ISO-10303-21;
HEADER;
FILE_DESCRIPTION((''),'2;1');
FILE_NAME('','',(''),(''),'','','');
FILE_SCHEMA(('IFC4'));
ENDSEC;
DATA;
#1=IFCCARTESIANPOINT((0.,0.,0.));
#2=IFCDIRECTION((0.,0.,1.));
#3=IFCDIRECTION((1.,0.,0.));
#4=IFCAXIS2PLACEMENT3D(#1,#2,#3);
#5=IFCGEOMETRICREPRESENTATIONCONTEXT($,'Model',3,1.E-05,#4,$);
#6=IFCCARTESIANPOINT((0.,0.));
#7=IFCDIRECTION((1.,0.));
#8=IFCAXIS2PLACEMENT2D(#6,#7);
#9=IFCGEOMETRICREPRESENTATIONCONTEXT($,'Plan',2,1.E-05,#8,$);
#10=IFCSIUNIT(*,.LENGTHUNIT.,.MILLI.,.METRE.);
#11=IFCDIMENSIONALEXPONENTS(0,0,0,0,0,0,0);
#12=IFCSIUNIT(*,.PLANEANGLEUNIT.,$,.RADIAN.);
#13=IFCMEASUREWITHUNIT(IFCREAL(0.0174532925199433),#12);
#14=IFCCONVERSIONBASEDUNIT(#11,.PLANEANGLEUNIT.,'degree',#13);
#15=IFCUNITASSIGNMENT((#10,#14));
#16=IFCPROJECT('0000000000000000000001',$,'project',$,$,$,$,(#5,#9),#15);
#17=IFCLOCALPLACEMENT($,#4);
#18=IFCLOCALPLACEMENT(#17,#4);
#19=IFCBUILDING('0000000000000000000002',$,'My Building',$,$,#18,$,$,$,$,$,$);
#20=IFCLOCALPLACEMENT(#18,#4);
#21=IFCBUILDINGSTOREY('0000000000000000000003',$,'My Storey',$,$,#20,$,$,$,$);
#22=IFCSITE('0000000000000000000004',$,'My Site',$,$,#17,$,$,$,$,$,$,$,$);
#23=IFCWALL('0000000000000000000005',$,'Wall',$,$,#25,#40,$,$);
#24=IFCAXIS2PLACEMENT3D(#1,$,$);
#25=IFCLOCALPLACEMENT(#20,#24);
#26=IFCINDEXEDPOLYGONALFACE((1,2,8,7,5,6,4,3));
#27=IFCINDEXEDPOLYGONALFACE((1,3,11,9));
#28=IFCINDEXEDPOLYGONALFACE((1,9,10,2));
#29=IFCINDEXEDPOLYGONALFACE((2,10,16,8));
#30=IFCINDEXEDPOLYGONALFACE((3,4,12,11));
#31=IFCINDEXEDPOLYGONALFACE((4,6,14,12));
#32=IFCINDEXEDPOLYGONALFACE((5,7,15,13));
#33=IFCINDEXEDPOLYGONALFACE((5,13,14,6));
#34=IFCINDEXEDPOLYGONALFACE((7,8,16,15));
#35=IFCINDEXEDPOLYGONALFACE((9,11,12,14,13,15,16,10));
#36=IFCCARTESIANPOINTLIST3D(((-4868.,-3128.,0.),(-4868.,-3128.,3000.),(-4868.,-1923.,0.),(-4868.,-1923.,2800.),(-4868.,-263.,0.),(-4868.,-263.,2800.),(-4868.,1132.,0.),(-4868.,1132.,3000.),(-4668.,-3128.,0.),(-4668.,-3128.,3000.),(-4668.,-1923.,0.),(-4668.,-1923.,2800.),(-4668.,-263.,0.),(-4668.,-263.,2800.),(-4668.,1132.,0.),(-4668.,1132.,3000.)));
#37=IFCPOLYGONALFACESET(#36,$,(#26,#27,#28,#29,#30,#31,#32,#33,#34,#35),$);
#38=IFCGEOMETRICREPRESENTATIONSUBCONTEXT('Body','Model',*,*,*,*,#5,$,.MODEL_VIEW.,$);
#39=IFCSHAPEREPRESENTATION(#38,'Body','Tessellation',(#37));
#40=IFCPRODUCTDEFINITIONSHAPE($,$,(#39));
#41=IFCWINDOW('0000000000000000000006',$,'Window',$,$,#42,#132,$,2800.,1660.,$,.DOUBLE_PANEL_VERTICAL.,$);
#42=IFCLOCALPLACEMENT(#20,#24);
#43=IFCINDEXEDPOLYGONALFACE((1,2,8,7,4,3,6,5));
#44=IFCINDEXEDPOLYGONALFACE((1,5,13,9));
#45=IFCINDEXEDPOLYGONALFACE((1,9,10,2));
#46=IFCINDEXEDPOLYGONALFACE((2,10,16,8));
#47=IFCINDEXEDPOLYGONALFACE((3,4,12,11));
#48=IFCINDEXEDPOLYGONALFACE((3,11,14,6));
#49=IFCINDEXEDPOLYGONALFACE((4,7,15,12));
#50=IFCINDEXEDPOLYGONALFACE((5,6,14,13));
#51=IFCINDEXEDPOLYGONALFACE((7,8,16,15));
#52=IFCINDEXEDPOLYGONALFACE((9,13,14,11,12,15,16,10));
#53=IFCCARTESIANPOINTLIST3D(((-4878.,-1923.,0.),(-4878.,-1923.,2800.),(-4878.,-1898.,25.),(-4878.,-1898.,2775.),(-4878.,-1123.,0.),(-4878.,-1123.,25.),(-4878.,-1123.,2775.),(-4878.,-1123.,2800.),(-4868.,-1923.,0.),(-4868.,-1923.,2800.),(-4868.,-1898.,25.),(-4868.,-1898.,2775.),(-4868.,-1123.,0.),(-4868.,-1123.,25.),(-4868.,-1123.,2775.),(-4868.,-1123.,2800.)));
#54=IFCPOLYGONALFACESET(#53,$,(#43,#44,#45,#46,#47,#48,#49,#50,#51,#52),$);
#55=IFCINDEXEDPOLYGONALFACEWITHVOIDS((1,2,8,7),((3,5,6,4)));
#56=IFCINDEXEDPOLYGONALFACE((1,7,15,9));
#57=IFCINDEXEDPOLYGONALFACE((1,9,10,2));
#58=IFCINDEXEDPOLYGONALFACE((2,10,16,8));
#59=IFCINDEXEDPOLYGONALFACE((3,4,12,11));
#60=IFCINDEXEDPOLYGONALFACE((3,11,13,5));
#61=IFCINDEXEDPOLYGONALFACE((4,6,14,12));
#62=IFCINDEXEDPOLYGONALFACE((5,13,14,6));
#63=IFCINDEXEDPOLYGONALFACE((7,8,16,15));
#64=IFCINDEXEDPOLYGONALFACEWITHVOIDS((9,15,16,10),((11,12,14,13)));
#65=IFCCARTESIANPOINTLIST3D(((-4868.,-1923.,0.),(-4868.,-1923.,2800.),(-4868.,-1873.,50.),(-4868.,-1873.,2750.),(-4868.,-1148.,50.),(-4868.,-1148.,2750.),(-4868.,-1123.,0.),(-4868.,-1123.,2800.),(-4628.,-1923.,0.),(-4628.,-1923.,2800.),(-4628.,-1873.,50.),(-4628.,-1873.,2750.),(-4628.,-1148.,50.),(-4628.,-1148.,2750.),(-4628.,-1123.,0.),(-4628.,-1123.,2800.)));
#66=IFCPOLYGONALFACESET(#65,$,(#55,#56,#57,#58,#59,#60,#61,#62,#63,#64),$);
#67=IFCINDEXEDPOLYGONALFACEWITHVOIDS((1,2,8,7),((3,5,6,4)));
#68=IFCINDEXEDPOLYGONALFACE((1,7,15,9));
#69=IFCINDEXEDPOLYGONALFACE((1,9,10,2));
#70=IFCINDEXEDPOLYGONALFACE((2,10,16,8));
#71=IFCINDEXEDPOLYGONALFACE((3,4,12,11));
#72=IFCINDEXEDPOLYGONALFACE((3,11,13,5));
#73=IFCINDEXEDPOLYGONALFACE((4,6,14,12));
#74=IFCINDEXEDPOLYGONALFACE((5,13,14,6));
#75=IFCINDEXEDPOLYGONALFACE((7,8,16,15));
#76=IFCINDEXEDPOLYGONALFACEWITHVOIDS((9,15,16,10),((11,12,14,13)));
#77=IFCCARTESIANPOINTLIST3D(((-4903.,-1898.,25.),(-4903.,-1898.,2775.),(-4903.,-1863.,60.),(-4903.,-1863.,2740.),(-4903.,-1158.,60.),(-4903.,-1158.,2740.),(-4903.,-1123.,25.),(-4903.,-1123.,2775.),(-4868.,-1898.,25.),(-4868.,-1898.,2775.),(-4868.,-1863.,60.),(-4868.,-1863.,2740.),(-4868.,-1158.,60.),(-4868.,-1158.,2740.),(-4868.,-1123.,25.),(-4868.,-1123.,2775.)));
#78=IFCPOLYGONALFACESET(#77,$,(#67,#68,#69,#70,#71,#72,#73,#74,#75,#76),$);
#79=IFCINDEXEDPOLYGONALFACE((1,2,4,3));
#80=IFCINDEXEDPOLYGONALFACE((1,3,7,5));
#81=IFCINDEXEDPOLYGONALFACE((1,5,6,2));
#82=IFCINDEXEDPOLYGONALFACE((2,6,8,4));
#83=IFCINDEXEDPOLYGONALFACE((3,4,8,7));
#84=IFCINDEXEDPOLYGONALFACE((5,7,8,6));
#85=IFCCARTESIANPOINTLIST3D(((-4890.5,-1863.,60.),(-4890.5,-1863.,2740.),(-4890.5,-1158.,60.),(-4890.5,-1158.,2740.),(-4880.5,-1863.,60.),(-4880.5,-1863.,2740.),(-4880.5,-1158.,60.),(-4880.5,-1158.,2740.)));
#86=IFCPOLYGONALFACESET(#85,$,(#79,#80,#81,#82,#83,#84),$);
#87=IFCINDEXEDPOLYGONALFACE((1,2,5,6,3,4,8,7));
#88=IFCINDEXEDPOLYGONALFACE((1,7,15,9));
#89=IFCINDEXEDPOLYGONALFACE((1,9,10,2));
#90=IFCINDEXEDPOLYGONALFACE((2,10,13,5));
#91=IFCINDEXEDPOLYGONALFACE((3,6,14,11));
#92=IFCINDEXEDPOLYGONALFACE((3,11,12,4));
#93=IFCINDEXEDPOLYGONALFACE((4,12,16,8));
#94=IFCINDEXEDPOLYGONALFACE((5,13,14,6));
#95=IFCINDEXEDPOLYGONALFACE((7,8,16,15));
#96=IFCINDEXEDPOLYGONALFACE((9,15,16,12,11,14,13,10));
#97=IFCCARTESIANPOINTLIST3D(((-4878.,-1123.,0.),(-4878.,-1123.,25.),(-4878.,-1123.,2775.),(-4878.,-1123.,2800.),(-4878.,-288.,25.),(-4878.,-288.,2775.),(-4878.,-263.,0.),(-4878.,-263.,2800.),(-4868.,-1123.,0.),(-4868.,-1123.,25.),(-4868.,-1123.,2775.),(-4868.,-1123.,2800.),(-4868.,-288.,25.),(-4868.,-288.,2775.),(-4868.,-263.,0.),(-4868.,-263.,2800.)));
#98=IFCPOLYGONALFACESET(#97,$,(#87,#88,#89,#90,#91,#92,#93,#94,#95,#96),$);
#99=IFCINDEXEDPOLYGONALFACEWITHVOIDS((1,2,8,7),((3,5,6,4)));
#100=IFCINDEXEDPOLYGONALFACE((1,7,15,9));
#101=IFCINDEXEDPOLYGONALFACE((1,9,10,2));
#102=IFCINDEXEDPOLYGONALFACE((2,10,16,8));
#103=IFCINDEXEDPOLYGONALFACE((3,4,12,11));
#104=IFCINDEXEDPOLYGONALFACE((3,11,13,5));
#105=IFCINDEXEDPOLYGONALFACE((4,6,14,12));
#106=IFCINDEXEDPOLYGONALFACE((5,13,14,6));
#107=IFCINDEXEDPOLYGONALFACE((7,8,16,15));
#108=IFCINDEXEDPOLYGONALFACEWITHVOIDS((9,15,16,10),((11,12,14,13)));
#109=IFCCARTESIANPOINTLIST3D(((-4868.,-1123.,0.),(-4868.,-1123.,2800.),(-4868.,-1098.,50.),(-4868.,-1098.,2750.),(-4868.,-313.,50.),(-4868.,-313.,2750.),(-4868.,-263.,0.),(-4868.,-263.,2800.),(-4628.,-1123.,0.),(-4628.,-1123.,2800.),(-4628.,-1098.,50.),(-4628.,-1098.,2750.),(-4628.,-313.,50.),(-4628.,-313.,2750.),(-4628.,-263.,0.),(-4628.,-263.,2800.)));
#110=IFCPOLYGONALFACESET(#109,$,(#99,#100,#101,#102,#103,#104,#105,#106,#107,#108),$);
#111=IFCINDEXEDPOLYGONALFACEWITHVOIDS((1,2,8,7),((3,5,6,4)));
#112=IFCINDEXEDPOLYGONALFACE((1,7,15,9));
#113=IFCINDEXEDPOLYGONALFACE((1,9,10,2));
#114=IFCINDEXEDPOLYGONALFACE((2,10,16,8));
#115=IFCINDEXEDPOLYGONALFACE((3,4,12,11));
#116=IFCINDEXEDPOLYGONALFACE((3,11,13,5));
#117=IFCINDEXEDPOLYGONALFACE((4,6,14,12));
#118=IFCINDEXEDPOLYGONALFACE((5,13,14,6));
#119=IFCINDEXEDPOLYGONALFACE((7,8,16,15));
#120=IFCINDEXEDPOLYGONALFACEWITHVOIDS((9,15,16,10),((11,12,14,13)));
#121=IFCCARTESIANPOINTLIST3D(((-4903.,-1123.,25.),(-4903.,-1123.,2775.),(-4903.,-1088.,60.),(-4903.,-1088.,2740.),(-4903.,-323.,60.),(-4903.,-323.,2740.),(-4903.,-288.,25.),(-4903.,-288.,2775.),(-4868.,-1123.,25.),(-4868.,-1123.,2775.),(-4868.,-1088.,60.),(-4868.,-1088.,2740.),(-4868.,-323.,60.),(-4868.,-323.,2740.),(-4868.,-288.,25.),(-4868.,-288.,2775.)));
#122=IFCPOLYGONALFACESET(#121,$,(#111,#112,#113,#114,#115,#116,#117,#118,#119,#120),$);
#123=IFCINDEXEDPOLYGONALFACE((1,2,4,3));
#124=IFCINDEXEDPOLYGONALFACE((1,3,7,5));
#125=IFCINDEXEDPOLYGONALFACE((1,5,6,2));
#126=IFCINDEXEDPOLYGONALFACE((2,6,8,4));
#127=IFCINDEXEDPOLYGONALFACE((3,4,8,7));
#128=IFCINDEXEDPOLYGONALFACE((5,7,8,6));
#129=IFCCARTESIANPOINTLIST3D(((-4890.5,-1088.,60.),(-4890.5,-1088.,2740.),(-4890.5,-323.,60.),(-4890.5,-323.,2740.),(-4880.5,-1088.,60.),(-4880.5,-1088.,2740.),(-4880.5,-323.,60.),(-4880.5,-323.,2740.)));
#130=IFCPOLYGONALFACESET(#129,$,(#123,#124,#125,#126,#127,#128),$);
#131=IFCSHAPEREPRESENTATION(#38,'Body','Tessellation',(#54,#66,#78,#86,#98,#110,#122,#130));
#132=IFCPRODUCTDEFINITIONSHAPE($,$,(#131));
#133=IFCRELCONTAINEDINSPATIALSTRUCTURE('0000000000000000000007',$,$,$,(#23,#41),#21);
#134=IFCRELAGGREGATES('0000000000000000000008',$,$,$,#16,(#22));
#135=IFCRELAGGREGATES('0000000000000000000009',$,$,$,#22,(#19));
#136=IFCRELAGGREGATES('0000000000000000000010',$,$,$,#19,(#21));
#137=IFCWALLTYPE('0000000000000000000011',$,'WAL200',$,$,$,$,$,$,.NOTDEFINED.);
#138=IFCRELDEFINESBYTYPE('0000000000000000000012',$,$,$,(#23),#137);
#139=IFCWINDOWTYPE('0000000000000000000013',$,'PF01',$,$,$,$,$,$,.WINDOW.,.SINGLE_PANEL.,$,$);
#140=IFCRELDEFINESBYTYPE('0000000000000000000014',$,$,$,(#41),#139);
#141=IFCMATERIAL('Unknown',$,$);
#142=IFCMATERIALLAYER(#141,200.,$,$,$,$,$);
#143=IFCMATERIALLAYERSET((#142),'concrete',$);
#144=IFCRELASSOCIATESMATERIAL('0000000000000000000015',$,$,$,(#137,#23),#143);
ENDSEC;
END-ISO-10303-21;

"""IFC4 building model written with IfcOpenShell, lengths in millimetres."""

from ifc_helpers import new_model, entity, si_unit, converted_unit, frame, origin_with_axes, origin_2d_with_axis, place, context, subcontext, project, spatial, line, indexed_curve, outline, extrude, shape, source, transform, mapped, material, layer, layer_set, layer_usage, type_object, type_shapes, element, fill, save


model = new_model("IFC4")

# Units and contexts
model_context = context("Model", 3, precision=1e-05, world=origin_with_axes())
plan_context = context("Plan", 2, precision=1e-05, world=origin_2d_with_axis())
body_context_1 = subcontext(model_context, "Body", "Model", "MODEL_VIEW")
body_context_2 = subcontext(plan_context, "Body", "Plan", "PLAN_VIEW")
ifc_project = project(units=[si_unit("LENGTHUNIT", "METRE", prefix="MILLI"), converted_unit("PLANEANGLEUNIT", "degree", entity("IfcReal", 0.0174532925199433), si_unit("PLANEANGLEUNIT", "RADIAN"), dimensions=[0, 0, 0, 0, 0, 0, 0])], contexts=[model_context, plan_context])

# Site, building, storey
site_placement = place(None, origin_with_axes())
site = spatial("IfcSite", under=ifc_project, at=site_placement, Name="My Site")
building_placement = place(site_placement, origin_with_axes())
building = spatial("IfcBuilding", under=site, at=building_placement, Name="My Building")
storey_placement = place(building_placement, origin_with_axes())
storey = spatial("IfcBuildingStorey", under=building, at=storey_placement, Name="My Storey")

# Shared definitions
ifc_material_1 = material(Name="Unknown")
ifc_layer_1 = layer(ifc_material_1, 200.0)
ifc_layer_set_1 = layer_set([ifc_layer_1], Name="concrete")
wall_type_1 = type_object("IfcWallType", Name="WAL200", PredefinedType="NOTDEFINED", material=ifc_layer_set_1)

# Wall, opening, window
ifc_layer_usage_1 = layer_usage(ifc_layer_set_1, "AXIS2", "POSITIVE", 0.0)
wall_1_placement = place(storey_placement, frame((-4868.0, 1132.0, 0.0), z_axis=(0.0, 0.0, 1.0), x_axis=(-0.000001, -1.0, 0.0)))
wall_1 = element("IfcWall", 1, at=wall_1_placement, inside=storey, type_object=wall_type_1, material=ifc_layer_usage_1, Name="Wall", context=body_context_1, shape_type="SweptSolid", body=[
    extrude(outline(indexed_curve([(0.0, 0.0), (0.0, 200.0), (4260.0, 200.0), (4260.0, 0.0), (0.0, 0.0)], self_intersect=False)), origin_with_axes(), (0.0, 0.0, 1.0), 3000.0),
])
shared_shape_1 = source(origin_with_axes(), body_context_1, "Body", "SweptSolid", [
    extrude(outline(indexed_curve([(0.0, 0.0), (1660.0, 0.0), (1660.0, 2800.0), (0.0, 2800.0)], segments=[line(1, 2, 3, 4, 1)])), frame((0.0, -100.0, 0.0), z_axis=(0.0, -1.0, 0.0), x_axis=(1.0, 0.0, 0.0)), (0.0, 0.0, -1.0), 400.0),
])
opening_1_placement = place(wall_1_placement, frame((3055.0, 290.0, 0.0), z_axis=(0.0, 0.0, 1.0), x_axis=(-1.0, 0.0, 0.0)))
opening_1 = element("IfcOpeningElement", 2, at=opening_1_placement, cuts=wall_1, PredefinedType="OPENING", context=body_context_1, shape_type="MappedRepresentation", body=[
    mapped(shared_shape_1, transform((0.0, 0.0, 0.0), x_axis=(1.0, 0.0, 0.0), y_axis=(0.0, 1.0, 0.0), z_axis=(0.0, 0.0, 1.0), scale=1.0)),
])
window_type = type_object("IfcWindowType", Name="PF01", PartitioningType="SINGLE_PANEL", PredefinedType="WINDOW")
shared_shape_2 = source(origin_with_axes(), body_context_1, "Body", "SolidModel", [
    extrude(outline(indexed_curve([(800.0, 0.0), (0.0, 0.0), (0.0, 2800.0), (800.0, 2800.0), (800.0, 2775.0), (25.0, 2775.0), (25.0, 25.0), (800.0, 25.0)], segments=[line(1, 2, 3, 4, 5, 6, 7, 8, 1)])), frame((0.0, 290.0, 0.0), z_axis=(0.0, -1.0, 0.0), x_axis=(1.0, 0.0, 0.0)), (0.0, 0.0, -1.0), 10.0),
    extrude(outline(indexed_curve([(0.0, 0.0), (800.0, 0.0), (800.0, 2800.0), (0.0, 2800.0)], segments=[line(1, 2, 3, 4, 1)]), holes=[indexed_curve([(50.0, 50.0), (775.0, 50.0), (775.0, 2750.0), (50.0, 2750.0)], segments=[line(1, 2, 3, 4, 1)])]), frame((0.0, 50.0, 0.0), z_axis=(0.0, -1.0, 0.0), x_axis=(1.0, 0.0, 0.0)), (0.0, 0.0, -1.0), 240.0),
    extrude(outline(indexed_curve([(0.0, 0.0), (775.0, 0.0), (775.0, 2750.0), (0.0, 2750.0)], segments=[line(1, 2, 3, 4, 1)]), holes=[indexed_curve([(35.0, 35.0), (740.0, 35.0), (740.0, 2715.0), (35.0, 2715.0)], segments=[line(1, 2, 3, 4, 1)])]), frame((25.0, 290.0, 25.0), z_axis=(0.0, -1.0, 0.0), x_axis=(1.0, 0.0, 0.0)), (0.0, 0.0, -1.0), 35.0),
    extrude(outline(indexed_curve([(35.0, 35.0), (740.0, 35.0), (740.0, 2715.0), (35.0, 2715.0)], segments=[line(1, 2, 3, 4, 1)])), frame((25.0, 302.5, 25.0), z_axis=(0.0, -1.0, 0.0), x_axis=(1.0, 0.0, 0.0)), (0.0, 0.0, -1.0), 10.0),
    extrude(outline(indexed_curve([(0.0, 2800.0), (860.0, 2800.0), (860.0, 0.0), (0.0, 0.0), (0.0, 25.0), (835.0, 25.0), (835.0, 2775.0), (0.0, 2775.0)], segments=[line(1, 2, 3, 4, 5, 6, 7, 8, 1)])), frame((800.0, 290.0, 0.0), z_axis=(0.0, -1.0, 0.0), x_axis=(1.0, 0.0, 0.0)), (0.0, 0.0, -1.0), 10.0),
    extrude(outline(indexed_curve([(0.0, 0.0), (860.0, 0.0), (860.0, 2800.0), (0.0, 2800.0)], segments=[line(1, 2, 3, 4, 1)]), holes=[indexed_curve([(25.0, 50.0), (810.0, 50.0), (810.0, 2750.0), (25.0, 2750.0)], segments=[line(1, 2, 3, 4, 1)])]), frame((800.0, 50.0, 0.0), z_axis=(0.0, -1.0, 0.0), x_axis=(1.0, 0.0, 0.0)), (0.0, 0.0, -1.0), 240.0),
    extrude(outline(indexed_curve([(0.0, 0.0), (835.0, 0.0), (835.0, 2750.0), (0.0, 2750.0)], segments=[line(1, 2, 3, 4, 1)]), holes=[indexed_curve([(35.0, 35.0), (800.0, 35.0), (800.0, 2715.0), (35.0, 2715.0)], segments=[line(1, 2, 3, 4, 1)])]), frame((800.0, 290.0, 25.0), z_axis=(0.0, -1.0, 0.0), x_axis=(1.0, 0.0, 0.0)), (0.0, 0.0, -1.0), 35.0),
    extrude(outline(indexed_curve([(35.0, 35.0), (800.0, 35.0), (800.0, 2715.0), (35.0, 2715.0)], segments=[line(1, 2, 3, 4, 1)])), frame((800.0, 302.5, 25.0), z_axis=(0.0, -1.0, 0.0), x_axis=(1.0, 0.0, 0.0)), (0.0, 0.0, -1.0), 10.0),
])
shared_shape_3 = source(origin_with_axes(), body_context_2, "Body", "Curve2D", [
    entity("IfcIndexedPolyCurve", entity("IfcCartesianPointList2D", [[50.0, 50.0], [775.0, 50.0]])),
    entity("IfcIndexedPolyCurve", entity("IfcCartesianPointList2D", [[0.0, 300.0], [25.0, 300.0], [25.0, 290.0], [50.0, 290.0], [50.0, 50.0], [0.0, 50.0]]), [entity("IfcLineIndex", [1, 2, 3, 4, 5, 6, 1])]),
    entity("IfcIndexedPolyCurve", entity("IfcCartesianPointList2D", [[800.0, 300.0], [800.0, 300.0], [800.0, 290.0], [775.0, 290.0], [775.0, 50.0], [800.0, 50.0]])),
    entity("IfcIndexedPolyCurve", entity("IfcCartesianPointList2D", [[25.0, 290.0], [60.0, 290.0], [60.0, 325.0], [25.0, 325.0]]), [entity("IfcLineIndex", [1, 2, 3, 4, 1])]),
    entity("IfcIndexedPolyCurve", entity("IfcCartesianPointList2D", [[800.0, 290.0], [765.0, 290.0], [765.0, 325.0], [800.0, 325.0]]), [entity("IfcLineIndex", [1, 2, 3, 4, 1])]),
    entity("IfcIndexedPolyCurve", entity("IfcCartesianPointList2D", [[60.0, 290.0], [765.0, 290.0]])),
    entity("IfcIndexedPolyCurve", entity("IfcCartesianPointList2D", [[60.0, 325.0], [765.0, 325.0]])),
    entity("IfcIndexedPolyCurve", entity("IfcCartesianPointList2D", [[60.0, 307.5], [765.0, 307.5]])),
    entity("IfcIndexedPolyCurve", entity("IfcCartesianPointList2D", [[825.0, 50.0], [1610.0, 50.0]])),
    entity("IfcIndexedPolyCurve", entity("IfcCartesianPointList2D", [[800.0, 300.0], [800.0, 300.0], [800.0, 290.0], [825.0, 290.0], [825.0, 50.0], [800.0, 50.0]])),
    entity("IfcIndexedPolyCurve", entity("IfcCartesianPointList2D", [[1660.0, 300.0], [1635.0, 300.0], [1635.0, 290.0], [1610.0, 290.0], [1610.0, 50.0], [1660.0, 50.0]]), [entity("IfcLineIndex", [1, 2, 3, 4, 5, 6, 1])]),
    entity("IfcIndexedPolyCurve", entity("IfcCartesianPointList2D", [[800.0, 290.0], [835.0, 290.0], [835.0, 325.0], [800.0, 325.0]]), [entity("IfcLineIndex", [1, 2, 3, 4, 1])]),
    entity("IfcIndexedPolyCurve", entity("IfcCartesianPointList2D", [[1635.0, 290.0], [1600.0, 290.0], [1600.0, 325.0], [1635.0, 325.0]]), [entity("IfcLineIndex", [1, 2, 3, 4, 1])]),
    entity("IfcIndexedPolyCurve", entity("IfcCartesianPointList2D", [[835.0, 290.0], [1600.0, 290.0]])),
    entity("IfcIndexedPolyCurve", entity("IfcCartesianPointList2D", [[835.0, 325.0], [1600.0, 325.0]])),
    entity("IfcIndexedPolyCurve", entity("IfcCartesianPointList2D", [[835.0, 307.5], [1600.0, 307.5]])),
])
type_shapes(window_type, [shared_shape_2, shared_shape_3])
window_placement = place(opening_1_placement, frame((0.0, 0.0, 0.0), z_axis=(0.0, 0.0, 1.0), x_axis=(1.0, 0.0, 0.0)))
window = element("IfcWindow", 3, at=window_placement, inside=storey, type_object=window_type, Name="Window", OverallHeight=2800.0, OverallWidth=1660.0, PartitioningType="DOUBLE_PANEL_VERTICAL", shapes=[
    shape(body_context_1, "Body", "MappedRepresentation", [mapped(shared_shape_2, transform((0.0, 0.0, 0.0), x_axis=(1.0, 0.0, 0.0), y_axis=(0.0, 1.0, 0.0), z_axis=(0.0, 0.0, 1.0), scale=1.0))]),
    shape(body_context_2, "Body", "MappedRepresentation", [mapped(shared_shape_3, transform((0.0, 0.0, 0.0), x_axis=(1.0, 0.0, 0.0), y_axis=(0.0, 1.0, 0.0), z_axis=(0.0, 0.0, 1.0), scale=1.0))]),
])
fill(opening_1, window)

save(model, "model.ifc")
